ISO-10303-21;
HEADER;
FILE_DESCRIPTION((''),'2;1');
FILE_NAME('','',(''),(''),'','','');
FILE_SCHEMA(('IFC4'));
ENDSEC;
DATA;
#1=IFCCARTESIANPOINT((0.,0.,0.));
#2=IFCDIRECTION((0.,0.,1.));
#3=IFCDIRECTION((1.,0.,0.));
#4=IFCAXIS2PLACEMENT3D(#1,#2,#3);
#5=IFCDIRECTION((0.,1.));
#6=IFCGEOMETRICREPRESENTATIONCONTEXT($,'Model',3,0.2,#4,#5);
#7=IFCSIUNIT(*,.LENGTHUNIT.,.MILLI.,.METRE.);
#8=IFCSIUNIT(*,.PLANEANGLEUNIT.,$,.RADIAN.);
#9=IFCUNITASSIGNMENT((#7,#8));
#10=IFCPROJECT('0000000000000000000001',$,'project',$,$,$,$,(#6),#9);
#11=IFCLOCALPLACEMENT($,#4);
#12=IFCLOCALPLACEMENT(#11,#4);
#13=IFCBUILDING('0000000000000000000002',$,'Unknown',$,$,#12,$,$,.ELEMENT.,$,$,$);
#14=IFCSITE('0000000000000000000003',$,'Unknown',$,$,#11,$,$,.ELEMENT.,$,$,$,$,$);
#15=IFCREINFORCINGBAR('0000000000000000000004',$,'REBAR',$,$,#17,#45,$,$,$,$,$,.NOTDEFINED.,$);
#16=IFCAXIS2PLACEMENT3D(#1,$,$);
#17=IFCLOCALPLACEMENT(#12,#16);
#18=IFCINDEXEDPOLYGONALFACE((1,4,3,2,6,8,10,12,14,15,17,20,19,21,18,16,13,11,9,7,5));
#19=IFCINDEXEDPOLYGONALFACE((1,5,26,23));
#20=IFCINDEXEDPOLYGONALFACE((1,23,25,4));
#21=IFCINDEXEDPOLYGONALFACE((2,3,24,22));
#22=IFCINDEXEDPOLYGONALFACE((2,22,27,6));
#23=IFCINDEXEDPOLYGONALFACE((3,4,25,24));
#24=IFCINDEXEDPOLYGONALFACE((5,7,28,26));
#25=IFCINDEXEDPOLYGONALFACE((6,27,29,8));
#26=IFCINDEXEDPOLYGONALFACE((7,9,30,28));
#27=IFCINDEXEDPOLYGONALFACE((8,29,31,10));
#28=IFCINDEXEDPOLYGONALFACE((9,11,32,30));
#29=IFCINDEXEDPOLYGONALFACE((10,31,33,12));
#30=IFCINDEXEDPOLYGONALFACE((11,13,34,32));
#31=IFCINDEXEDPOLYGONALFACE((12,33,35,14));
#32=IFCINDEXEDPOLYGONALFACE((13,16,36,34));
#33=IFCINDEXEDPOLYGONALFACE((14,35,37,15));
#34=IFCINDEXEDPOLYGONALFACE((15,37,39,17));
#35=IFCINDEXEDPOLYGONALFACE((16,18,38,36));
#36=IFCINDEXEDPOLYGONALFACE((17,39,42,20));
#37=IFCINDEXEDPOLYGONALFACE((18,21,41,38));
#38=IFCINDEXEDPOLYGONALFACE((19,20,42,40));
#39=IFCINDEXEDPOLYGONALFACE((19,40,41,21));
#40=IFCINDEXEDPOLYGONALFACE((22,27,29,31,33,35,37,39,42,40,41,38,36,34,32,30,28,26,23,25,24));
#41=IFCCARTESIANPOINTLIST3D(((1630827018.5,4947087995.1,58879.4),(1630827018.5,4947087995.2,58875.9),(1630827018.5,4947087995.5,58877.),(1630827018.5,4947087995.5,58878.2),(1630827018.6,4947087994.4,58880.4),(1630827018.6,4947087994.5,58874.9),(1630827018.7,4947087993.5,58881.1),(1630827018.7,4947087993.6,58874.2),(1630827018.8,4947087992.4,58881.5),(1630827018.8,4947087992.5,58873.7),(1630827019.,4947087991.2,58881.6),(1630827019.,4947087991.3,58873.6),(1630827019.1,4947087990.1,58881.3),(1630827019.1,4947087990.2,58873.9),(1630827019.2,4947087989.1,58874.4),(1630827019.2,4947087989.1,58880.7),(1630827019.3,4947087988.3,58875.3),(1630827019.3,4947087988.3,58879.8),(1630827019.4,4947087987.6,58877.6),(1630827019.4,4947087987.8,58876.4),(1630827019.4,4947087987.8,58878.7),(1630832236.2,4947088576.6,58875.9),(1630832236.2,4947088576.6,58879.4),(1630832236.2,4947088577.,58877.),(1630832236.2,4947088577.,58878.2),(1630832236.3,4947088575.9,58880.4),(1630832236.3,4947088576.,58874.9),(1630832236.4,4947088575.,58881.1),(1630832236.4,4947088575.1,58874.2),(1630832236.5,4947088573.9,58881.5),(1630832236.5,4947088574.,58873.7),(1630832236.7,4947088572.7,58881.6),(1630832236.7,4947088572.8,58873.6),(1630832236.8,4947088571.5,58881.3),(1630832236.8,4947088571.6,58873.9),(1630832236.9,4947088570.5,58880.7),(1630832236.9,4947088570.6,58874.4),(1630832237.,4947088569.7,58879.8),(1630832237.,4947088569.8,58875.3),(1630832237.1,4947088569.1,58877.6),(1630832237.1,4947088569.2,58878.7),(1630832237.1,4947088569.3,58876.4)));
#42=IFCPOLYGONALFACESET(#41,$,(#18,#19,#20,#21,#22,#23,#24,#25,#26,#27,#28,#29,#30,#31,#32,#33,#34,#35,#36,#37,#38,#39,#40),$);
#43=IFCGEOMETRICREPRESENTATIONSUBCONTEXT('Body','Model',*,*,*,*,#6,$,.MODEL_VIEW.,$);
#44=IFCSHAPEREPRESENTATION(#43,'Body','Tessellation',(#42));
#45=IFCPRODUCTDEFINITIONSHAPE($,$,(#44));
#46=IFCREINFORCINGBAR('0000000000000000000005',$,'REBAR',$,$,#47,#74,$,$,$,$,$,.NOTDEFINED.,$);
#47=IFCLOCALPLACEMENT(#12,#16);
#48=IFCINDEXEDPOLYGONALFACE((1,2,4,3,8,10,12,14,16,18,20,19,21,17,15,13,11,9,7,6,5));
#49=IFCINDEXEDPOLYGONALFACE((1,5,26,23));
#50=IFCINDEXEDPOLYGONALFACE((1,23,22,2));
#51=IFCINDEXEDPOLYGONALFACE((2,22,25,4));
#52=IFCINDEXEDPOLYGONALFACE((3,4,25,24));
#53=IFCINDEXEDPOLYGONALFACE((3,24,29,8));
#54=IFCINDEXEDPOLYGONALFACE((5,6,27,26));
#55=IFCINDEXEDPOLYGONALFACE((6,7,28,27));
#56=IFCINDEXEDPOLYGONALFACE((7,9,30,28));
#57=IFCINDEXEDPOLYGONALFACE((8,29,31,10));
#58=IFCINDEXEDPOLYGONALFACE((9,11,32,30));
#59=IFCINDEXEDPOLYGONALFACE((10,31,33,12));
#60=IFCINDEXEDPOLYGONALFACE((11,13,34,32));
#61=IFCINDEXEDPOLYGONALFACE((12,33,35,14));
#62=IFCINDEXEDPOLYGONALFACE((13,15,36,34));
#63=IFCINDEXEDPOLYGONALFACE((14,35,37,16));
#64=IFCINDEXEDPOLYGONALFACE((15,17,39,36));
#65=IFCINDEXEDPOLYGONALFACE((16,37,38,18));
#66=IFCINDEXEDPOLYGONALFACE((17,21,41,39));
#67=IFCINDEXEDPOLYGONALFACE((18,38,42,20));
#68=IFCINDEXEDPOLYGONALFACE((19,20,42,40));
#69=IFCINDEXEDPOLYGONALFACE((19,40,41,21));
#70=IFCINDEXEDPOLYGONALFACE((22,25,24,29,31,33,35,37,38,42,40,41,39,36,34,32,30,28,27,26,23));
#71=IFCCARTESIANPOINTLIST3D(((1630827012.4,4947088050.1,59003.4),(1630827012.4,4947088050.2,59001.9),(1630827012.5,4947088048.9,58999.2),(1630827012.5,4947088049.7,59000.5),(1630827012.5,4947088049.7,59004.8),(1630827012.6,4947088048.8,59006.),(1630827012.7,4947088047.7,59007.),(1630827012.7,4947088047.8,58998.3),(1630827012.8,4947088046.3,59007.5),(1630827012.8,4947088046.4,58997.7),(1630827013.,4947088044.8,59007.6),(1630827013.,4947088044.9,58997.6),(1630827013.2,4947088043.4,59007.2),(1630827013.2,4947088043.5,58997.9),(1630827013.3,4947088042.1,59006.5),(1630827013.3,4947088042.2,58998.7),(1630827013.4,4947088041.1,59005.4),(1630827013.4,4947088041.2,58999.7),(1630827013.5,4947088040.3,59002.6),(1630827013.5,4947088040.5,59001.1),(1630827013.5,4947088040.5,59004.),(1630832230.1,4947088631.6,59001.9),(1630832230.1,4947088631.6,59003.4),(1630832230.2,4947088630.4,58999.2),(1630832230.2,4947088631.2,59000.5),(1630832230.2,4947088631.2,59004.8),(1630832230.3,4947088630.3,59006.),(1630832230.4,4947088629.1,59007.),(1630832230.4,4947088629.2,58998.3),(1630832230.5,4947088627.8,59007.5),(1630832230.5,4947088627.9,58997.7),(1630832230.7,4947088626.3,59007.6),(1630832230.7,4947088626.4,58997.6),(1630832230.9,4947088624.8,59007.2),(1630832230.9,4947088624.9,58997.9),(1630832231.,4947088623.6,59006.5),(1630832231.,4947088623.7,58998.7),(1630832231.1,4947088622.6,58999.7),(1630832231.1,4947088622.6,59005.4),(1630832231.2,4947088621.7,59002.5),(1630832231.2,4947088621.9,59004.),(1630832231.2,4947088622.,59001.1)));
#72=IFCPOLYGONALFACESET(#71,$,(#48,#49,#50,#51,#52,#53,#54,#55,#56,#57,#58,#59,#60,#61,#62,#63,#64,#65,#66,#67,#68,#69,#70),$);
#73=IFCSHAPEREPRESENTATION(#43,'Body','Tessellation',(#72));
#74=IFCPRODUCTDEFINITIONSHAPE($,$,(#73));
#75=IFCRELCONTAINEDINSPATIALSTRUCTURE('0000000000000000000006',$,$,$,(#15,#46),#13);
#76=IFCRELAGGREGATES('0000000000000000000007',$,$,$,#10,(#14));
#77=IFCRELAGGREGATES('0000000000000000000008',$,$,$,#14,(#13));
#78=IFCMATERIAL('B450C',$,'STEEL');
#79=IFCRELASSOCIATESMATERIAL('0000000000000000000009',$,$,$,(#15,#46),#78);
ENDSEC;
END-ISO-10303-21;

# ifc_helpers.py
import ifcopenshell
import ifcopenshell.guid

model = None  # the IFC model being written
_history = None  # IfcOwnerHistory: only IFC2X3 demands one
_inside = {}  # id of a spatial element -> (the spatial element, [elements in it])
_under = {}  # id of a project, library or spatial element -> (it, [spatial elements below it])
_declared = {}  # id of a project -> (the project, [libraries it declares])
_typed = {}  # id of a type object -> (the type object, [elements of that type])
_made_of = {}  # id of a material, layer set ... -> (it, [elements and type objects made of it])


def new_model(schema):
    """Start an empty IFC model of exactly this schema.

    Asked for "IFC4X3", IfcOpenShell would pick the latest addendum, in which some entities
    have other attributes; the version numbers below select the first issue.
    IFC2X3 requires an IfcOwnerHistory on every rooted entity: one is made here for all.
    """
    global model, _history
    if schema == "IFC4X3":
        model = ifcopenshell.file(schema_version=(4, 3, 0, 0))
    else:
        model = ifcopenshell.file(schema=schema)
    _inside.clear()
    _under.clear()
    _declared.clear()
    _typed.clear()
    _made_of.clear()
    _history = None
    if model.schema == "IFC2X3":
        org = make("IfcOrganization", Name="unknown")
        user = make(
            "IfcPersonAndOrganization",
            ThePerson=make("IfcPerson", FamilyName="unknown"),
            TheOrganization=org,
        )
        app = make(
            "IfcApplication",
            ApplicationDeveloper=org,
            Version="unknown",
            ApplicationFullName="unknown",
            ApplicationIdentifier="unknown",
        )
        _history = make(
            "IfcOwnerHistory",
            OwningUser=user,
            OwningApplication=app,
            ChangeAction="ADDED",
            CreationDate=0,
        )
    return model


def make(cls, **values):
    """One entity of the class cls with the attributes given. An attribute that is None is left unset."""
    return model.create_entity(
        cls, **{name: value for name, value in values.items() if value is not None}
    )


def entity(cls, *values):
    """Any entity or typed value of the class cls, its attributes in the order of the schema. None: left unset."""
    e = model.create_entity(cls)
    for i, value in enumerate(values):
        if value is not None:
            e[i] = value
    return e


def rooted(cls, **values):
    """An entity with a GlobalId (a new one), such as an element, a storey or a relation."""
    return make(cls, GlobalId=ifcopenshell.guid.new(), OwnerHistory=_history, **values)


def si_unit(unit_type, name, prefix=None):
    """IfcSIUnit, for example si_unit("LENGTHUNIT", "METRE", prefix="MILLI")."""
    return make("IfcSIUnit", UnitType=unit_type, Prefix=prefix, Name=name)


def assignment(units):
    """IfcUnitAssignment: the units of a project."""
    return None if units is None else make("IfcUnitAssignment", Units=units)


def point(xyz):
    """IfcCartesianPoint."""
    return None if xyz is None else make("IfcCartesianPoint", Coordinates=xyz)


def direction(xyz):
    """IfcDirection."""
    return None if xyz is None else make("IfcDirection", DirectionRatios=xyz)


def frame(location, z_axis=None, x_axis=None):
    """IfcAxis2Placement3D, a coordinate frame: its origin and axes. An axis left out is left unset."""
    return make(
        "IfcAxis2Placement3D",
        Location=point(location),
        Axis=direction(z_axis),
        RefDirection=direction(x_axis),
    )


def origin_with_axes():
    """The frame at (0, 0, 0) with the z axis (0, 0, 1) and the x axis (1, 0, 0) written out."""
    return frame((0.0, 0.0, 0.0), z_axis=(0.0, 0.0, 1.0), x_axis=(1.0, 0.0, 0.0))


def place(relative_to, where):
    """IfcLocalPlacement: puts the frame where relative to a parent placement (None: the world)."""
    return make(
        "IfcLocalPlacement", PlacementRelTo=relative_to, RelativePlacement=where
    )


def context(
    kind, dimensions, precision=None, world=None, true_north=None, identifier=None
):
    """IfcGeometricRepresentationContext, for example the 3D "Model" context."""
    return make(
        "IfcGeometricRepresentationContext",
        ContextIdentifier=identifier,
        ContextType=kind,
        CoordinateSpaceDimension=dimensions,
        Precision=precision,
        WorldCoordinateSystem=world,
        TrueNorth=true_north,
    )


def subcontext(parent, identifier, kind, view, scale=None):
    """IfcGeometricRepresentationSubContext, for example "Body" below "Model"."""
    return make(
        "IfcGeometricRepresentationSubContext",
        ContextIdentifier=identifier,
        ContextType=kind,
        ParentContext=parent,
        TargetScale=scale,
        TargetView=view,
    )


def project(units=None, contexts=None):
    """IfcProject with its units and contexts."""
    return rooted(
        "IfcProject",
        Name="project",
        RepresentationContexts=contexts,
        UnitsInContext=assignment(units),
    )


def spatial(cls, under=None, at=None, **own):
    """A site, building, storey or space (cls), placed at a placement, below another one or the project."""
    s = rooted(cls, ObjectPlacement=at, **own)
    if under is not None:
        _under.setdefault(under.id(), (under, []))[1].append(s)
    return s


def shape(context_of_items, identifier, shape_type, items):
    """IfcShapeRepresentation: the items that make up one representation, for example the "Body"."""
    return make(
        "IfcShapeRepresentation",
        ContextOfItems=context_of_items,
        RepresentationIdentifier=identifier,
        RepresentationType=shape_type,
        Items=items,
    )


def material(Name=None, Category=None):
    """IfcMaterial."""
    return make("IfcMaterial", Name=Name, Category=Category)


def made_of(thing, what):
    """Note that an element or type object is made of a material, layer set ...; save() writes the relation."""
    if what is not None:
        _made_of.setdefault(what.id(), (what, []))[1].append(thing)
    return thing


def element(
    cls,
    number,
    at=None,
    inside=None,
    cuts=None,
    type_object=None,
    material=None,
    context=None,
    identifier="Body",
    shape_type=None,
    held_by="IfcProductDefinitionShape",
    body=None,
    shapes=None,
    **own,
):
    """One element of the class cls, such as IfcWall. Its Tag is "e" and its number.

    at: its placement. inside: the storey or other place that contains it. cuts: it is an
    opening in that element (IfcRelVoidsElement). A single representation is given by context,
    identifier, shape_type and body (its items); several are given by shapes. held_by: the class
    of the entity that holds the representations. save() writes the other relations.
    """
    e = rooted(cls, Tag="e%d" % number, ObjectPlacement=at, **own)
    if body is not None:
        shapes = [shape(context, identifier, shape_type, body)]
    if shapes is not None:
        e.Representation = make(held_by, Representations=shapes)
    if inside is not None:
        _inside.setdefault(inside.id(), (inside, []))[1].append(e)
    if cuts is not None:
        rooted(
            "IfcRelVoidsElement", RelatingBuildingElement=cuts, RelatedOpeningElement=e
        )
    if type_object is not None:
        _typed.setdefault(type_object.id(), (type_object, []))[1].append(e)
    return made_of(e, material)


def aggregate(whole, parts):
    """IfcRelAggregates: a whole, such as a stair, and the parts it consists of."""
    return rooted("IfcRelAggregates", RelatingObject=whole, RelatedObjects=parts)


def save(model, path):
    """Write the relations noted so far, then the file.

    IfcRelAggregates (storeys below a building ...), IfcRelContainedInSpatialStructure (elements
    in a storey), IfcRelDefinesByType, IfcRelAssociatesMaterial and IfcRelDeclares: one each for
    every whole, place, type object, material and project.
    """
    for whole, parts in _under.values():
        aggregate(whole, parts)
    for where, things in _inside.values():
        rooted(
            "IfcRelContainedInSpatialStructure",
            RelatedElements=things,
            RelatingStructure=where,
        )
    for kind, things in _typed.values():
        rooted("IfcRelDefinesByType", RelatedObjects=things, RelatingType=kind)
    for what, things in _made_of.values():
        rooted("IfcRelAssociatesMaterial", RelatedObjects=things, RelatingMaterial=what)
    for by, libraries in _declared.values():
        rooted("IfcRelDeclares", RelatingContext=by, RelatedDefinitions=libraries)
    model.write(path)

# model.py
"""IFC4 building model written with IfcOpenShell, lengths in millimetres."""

from ifc_helpers import new_model, entity, si_unit, direction, frame, origin_with_axes, place, context, subcontext, project, spatial, material, element, save


model = new_model("IFC4")

# Units and contexts
model_context = context("Model", 3, precision=0.2, world=origin_with_axes(), true_north=direction((0.0, 1.0)))
body_context = subcontext(model_context, "Body", "Model", "MODEL_VIEW")
ifc_project = project(units=[si_unit("LENGTHUNIT", "METRE", prefix="MILLI"), si_unit("PLANEANGLEUNIT", "RADIAN")], contexts=[model_context])

# Site, building
site_placement = place(None, origin_with_axes())
site = spatial("IfcSite", under=ifc_project, at=site_placement, Name="Unknown", CompositionType="ELEMENT")
building_placement = place(site_placement, origin_with_axes())
building = spatial("IfcBuilding", under=site, at=building_placement, Name="Unknown", CompositionType="ELEMENT")

# Reinforcing bars
ifc_material = material(Name="B450C", Category="STEEL")
reinforcing_bar_1_placement = place(building_placement, frame((1630832236.6, 4947088573.0, 58877.6), z_axis=(0.007106, -0.063762, -0.99794), x_axis=(-0.993847, -0.110757, 0.0)))
element("IfcReinforcingBar", 1, at=reinforcing_bar_1_placement, inside=building, material=ifc_material, Name="REBAR", PredefinedType="NOTDEFINED", context=body_context, shape_type="AdvancedSweptSolid", body=[
    entity("IfcSweptDiskSolid", entity("IfcIndexedPolyCurve", entity("IfcCartesianPointList3D", [[0.0, 0.0, 0.0], [5250.0, 0.0, 0.0]]), [entity("IfcLineIndex", [1, 2])]), 4.0),
])
reinforcing_bar_2_placement = place(building_placement, frame((1630832230.7, 4947088626.7, 59002.6), z_axis=(0.007106, -0.063762, -0.99794), x_axis=(-0.993847, -0.110757, 0.0)))
element("IfcReinforcingBar", 2, at=reinforcing_bar_2_placement, inside=building, material=ifc_material, Name="REBAR", PredefinedType="NOTDEFINED", context=body_context, shape_type="AdvancedSweptSolid", body=[
    entity("IfcSweptDiskSolid", entity("IfcIndexedPolyCurve", entity("IfcCartesianPointList3D", [[0.0, 0.0, 0.0], [5250.0, 0.0, 0.0]]), [entity("IfcLineIndex", [1, 2])]), 5.0),
])

save(model, "model.ifc")
